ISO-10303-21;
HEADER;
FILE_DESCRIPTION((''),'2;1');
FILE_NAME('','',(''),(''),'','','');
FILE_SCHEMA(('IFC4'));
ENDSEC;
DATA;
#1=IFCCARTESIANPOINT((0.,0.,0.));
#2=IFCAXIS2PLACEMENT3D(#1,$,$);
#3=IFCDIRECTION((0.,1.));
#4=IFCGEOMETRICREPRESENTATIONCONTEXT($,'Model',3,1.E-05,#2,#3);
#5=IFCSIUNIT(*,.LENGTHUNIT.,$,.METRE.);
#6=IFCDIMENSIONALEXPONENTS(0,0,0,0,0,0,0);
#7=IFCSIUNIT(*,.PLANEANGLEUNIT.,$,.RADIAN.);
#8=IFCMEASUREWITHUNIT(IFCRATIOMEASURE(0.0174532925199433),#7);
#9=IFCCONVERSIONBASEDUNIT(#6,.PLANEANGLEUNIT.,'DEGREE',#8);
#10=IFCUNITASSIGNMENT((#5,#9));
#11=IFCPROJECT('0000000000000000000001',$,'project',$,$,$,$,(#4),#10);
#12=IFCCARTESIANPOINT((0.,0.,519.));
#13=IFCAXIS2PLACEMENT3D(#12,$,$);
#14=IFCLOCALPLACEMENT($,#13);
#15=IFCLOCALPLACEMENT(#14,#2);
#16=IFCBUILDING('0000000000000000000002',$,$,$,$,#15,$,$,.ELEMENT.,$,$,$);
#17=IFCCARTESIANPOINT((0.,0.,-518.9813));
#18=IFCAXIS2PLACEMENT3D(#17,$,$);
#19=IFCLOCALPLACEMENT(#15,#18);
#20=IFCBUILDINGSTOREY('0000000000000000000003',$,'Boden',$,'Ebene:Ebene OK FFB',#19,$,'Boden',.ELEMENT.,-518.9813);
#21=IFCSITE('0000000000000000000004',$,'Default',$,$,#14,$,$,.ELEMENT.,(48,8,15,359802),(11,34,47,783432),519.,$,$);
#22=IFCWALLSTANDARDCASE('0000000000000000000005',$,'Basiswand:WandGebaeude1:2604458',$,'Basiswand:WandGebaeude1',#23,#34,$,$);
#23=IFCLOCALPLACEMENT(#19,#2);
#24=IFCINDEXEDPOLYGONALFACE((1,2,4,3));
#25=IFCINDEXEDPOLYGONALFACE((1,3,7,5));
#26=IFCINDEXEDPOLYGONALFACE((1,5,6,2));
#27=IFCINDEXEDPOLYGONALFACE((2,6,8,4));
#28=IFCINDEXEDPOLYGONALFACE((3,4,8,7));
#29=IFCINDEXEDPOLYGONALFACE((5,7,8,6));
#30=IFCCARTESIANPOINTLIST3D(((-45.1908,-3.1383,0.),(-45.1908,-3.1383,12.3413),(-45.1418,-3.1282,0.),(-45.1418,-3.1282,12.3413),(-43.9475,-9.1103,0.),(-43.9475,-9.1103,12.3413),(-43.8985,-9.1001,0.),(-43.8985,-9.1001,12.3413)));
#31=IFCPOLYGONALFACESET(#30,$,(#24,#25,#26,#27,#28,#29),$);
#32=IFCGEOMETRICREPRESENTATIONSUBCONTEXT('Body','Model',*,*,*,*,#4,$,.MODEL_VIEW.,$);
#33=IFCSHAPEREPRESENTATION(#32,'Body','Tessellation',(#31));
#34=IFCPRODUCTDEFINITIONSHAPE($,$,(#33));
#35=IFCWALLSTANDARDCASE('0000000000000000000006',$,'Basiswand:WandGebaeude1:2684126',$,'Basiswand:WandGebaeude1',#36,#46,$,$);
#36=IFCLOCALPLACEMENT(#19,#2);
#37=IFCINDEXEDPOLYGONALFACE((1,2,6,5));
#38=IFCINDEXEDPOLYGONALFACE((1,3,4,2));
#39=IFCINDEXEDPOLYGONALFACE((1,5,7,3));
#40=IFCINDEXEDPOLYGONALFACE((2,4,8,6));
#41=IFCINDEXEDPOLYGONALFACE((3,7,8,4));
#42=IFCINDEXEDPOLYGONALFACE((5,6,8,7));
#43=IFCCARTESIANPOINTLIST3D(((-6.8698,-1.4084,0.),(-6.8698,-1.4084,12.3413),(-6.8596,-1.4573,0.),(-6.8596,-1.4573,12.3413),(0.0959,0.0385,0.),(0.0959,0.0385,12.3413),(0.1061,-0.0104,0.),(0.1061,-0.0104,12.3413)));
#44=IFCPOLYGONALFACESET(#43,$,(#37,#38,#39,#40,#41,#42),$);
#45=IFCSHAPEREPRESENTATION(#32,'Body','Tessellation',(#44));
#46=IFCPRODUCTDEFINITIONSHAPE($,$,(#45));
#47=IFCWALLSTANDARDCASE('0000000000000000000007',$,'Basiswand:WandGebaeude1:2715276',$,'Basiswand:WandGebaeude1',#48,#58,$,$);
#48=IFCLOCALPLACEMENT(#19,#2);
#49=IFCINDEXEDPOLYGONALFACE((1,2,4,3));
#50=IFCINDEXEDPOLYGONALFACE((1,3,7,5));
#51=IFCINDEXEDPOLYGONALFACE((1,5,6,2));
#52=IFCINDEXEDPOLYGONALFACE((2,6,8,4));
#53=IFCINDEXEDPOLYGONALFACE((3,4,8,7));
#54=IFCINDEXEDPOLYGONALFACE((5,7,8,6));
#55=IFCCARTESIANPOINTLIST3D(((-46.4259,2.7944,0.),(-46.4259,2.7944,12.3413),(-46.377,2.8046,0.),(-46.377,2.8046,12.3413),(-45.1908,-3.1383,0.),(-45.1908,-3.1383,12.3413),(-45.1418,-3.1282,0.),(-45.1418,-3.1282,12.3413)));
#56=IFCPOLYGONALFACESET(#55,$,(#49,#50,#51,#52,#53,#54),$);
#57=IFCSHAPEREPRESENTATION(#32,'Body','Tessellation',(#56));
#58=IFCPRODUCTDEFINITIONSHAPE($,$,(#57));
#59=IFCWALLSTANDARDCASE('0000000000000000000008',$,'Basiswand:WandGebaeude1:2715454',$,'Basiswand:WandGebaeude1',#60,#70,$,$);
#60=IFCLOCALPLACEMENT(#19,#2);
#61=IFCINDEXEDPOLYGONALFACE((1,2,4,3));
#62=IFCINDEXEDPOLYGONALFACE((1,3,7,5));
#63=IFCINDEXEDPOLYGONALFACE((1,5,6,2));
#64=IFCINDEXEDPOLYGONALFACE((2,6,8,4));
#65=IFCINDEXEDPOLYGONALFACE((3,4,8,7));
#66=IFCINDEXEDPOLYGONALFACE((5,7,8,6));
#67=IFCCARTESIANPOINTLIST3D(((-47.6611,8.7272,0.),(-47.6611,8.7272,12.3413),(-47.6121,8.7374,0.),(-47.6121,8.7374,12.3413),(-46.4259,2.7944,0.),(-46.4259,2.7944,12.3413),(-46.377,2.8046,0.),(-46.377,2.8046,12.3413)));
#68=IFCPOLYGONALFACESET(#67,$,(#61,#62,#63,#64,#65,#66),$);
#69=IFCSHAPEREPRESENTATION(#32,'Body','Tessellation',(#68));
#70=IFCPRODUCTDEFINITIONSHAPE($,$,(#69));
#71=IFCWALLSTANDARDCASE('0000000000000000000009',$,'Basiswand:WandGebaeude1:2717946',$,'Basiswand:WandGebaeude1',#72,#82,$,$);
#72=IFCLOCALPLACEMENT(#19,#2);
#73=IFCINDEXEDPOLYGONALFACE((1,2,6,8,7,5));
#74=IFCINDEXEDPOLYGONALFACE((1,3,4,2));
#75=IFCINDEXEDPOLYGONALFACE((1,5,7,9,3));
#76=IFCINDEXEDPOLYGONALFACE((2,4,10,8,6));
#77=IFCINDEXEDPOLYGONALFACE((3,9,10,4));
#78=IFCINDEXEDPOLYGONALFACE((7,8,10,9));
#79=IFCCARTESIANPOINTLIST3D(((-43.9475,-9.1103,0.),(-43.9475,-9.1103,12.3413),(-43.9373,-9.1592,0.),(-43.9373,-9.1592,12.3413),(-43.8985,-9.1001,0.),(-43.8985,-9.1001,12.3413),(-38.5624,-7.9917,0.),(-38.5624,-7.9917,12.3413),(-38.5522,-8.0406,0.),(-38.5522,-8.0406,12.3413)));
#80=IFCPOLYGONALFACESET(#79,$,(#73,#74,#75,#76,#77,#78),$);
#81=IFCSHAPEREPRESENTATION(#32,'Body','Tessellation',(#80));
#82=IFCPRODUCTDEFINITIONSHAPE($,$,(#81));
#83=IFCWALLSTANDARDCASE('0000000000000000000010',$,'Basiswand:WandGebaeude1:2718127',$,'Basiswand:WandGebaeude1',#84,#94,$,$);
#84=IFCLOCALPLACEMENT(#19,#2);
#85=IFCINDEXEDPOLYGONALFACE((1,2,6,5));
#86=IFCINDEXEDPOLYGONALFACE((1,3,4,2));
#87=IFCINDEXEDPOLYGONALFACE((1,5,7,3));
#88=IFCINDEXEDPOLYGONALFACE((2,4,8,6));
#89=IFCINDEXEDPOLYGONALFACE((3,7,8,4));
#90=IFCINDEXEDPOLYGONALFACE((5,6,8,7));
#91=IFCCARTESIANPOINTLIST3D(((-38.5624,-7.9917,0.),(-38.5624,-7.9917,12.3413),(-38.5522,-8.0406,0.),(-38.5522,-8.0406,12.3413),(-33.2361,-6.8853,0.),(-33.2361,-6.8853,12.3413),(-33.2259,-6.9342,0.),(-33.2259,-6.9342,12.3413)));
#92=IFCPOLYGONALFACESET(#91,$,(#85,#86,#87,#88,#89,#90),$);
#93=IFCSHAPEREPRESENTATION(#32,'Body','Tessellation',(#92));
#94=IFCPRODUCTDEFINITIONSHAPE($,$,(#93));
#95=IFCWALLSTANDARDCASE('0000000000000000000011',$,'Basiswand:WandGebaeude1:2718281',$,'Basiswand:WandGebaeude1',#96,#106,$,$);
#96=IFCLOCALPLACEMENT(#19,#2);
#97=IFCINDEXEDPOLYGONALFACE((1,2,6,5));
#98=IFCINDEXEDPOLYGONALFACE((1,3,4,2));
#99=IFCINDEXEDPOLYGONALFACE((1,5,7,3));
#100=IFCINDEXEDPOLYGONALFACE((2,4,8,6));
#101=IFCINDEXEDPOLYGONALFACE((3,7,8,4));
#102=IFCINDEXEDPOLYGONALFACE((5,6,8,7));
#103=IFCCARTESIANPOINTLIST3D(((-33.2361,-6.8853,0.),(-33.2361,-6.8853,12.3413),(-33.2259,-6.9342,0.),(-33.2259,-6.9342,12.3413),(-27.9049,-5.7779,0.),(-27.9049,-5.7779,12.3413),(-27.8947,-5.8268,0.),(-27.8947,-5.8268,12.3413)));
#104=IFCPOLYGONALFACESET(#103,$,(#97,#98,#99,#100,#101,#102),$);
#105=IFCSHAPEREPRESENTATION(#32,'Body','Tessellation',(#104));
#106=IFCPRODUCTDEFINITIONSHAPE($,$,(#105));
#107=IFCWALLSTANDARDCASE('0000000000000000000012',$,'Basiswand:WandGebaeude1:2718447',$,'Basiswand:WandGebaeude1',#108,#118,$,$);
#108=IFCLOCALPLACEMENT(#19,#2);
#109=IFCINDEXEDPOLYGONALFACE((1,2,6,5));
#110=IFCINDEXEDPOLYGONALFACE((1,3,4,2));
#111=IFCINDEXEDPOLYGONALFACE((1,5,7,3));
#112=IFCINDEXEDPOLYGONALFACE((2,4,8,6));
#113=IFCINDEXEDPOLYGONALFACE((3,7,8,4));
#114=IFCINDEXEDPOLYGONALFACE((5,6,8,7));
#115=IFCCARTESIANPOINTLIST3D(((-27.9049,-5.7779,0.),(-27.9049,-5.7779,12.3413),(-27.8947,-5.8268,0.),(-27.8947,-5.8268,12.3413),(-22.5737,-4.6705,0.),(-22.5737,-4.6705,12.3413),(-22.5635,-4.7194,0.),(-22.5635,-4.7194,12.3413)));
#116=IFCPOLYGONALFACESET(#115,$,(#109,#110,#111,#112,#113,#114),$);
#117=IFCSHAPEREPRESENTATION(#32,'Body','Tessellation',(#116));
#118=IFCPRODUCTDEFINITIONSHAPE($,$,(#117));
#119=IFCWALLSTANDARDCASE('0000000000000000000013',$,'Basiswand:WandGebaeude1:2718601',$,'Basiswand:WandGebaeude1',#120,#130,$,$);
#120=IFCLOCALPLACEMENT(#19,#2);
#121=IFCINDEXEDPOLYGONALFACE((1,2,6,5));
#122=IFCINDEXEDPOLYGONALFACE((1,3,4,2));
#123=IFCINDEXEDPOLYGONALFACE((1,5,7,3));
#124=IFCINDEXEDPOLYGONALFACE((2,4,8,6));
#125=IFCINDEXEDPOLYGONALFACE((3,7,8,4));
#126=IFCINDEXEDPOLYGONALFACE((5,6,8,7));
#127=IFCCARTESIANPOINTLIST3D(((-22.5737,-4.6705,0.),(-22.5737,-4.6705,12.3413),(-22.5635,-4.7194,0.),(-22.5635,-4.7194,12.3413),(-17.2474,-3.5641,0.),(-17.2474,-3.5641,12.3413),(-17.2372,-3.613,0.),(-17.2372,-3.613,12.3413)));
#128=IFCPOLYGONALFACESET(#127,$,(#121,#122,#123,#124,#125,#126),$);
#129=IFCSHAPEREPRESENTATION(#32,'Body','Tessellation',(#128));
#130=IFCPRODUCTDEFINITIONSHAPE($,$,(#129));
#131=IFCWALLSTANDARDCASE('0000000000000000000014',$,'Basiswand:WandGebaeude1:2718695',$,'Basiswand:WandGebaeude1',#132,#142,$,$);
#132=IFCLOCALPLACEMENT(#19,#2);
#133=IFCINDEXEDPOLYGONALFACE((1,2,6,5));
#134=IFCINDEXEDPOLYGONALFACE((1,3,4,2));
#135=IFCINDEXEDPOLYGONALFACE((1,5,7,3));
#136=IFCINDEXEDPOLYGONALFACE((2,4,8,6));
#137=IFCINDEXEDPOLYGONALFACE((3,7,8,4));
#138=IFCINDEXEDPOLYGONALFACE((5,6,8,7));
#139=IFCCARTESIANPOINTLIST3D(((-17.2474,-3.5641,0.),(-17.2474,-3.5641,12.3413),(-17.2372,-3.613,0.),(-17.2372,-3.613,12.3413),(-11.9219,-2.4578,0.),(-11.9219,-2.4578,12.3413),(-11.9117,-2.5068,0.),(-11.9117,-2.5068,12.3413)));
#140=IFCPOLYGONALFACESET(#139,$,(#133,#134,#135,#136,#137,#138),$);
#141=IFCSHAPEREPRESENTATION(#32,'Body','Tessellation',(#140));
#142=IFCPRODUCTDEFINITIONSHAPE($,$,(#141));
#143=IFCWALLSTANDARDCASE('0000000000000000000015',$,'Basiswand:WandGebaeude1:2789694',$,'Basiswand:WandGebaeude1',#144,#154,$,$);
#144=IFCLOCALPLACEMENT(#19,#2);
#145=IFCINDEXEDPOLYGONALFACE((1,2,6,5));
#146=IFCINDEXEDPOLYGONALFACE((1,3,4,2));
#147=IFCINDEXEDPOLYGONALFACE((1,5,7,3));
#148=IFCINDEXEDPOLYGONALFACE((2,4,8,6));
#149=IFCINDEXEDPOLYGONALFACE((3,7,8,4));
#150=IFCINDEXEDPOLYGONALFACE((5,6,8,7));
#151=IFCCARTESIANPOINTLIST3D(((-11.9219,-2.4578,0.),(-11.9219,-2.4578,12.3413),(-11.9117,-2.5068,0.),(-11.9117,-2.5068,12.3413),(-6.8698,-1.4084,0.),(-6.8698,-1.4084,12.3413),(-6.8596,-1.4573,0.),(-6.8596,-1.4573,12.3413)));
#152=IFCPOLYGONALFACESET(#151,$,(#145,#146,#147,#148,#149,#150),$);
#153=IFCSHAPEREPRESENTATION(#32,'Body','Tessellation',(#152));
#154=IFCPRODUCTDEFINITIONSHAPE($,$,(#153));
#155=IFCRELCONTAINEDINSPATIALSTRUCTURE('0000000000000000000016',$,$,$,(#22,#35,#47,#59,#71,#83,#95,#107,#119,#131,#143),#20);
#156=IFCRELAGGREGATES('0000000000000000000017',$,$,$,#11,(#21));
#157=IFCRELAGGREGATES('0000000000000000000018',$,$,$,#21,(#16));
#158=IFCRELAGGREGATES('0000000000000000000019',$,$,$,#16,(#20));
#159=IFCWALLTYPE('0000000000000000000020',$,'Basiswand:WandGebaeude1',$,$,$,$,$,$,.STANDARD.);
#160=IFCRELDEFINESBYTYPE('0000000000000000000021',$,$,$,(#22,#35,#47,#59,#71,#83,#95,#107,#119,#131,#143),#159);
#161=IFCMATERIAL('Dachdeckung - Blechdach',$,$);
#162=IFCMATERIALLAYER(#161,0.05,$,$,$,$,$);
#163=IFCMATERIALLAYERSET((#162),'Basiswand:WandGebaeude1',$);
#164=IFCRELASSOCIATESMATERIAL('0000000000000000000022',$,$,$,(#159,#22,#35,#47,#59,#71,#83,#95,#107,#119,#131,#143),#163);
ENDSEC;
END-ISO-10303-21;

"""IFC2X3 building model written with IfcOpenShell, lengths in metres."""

from ifc_helpers import new_model, entity, si_unit, converted_unit, direction, frame, frame_2d, origin, place, context, subcontext, project, spatial, polyline, rectangle, outline, extrude, material, layer, layer_set, layer_usage, type_object, element, save


model = new_model("IFC2X3")

# Units and contexts
model_context = context("Model", 3, precision=1e-05, world=origin(), true_north=direction((0.0, 1.0)))
body_context = subcontext(model_context, "Body", "Model", "MODEL_VIEW")
ifc_project = project(units=[si_unit("LENGTHUNIT", "METRE"), converted_unit("PLANEANGLEUNIT", "DEGREE", entity("IfcRatioMeasure", 0.0174532925199433), si_unit("PLANEANGLEUNIT", "RADIAN"), dimensions=[0, 0, 0, 0, 0, 0, 0])], contexts=[model_context])

# Site, building, storey
site_placement = place(None, frame((0.0, 0.0, 519.0)))
site = spatial("IfcSite", under=ifc_project, at=site_placement, Name="Default", CompositionType="ELEMENT", RefLatitude=(48, 8, 15, 359802), RefLongitude=(11, 34, 47, 783432), RefElevation=519.0)
building_placement = place(site_placement, origin())
building = spatial("IfcBuilding", under=site, at=building_placement, CompositionType="ELEMENT")
storey_placement = place(building_placement, frame((0.0, 0.0, -518.9813)))
storey = spatial("IfcBuildingStorey", under=building, at=storey_placement, Name="Boden", ObjectType="Ebene:Ebene OK FFB", LongName="Boden", CompositionType="ELEMENT", Elevation=-518.9813)

# Walls
ifc_material_1 = material(Name="Dachdeckung - Blechdach")
ifc_layer_1 = layer(ifc_material_1, 0.05)
ifc_layer_set_1 = layer_set([ifc_layer_1], Name="Basiswand:WandGebaeude1")
ifc_layer_usage_1 = layer_usage(ifc_layer_set_1, "AXIS2", "NEGATIVE", 0.025)
wall_type = type_object("IfcWallType", Name="Basiswand:WandGebaeude1", PredefinedType="STANDARD", material=ifc_layer_set_1)
wall_1_placement = place(storey_placement, frame((-43.923, -9.1052, 0.0), z_axis=(0.0, 0.0, 1.0), x_axis=(-0.20382, 0.979008, 0.0)))
element("IfcWallStandardCase", 1, at=wall_1_placement, inside=storey, type_object=wall_type, material=ifc_layer_usage_1, Name="Basiswand:WandGebaeude1:2604458", ObjectType="Basiswand:WandGebaeude1", context=body_context, shape_type="SweptSolid", body=[
    extrude(outline(polyline([(6.1, -0.025), (6.1, 0.025), (0.0, 0.025), (0.0, -0.025), (6.1, -0.025)])), origin(), (0.0, 0.0, 1.0), 12.3413),
])
ifc_layer_usage_2 = layer_usage(ifc_layer_set_1, "AXIS2", "NEGATIVE", 0.025)
wall_2_placement = place(storey_placement, frame((0.101, 0.0141, 0.0), z_axis=(0.0, 0.0, 1.0), x_axis=(-0.9791, -0.203381, 0.0)))
element("IfcWallStandardCase", 2, at=wall_2_placement, inside=storey, type_object=wall_type, material=ifc_layer_usage_2, Name="Basiswand:WandGebaeude1:2684126", ObjectType="Basiswand:WandGebaeude1", context=body_context, shape_type="SweptSolid", body=[
    extrude(outline(polyline([(7.1144, -0.025), (7.1144, 0.025), (0.0, 0.025), (0.0, -0.025), (7.1144, -0.025)])), origin(), (0.0, 0.0, 1.0), 12.3413),
])
ifc_layer_usage_3 = layer_usage(ifc_layer_set_1, "AXIS2", "NEGATIVE", 0.025)
wall_3_placement = place(storey_placement, frame((-45.1663, -3.1332, 0.0), z_axis=(0.0, 0.0, 1.0), x_axis=(-0.20382, 0.979008, 0.0)))
element("IfcWallStandardCase", 3, at=wall_3_placement, inside=storey, type_object=wall_type, material=ifc_layer_usage_3, Name="Basiswand:WandGebaeude1:2715276", ObjectType="Basiswand:WandGebaeude1", context=body_context, shape_type="SweptSolid", body=[
    extrude(rectangle(XDim=6.06, YDim=0.05, at=frame_2d((3.03, 0.0), x_axis=(-1.0, 0.0))), origin(), (0.0, 0.0, 1.0), 12.3413),
])
ifc_layer_usage_4 = layer_usage(ifc_layer_set_1, "AXIS2", "NEGATIVE", 0.025)
wall_4_placement = place(storey_placement, frame((-46.4014, 2.7995, 0.0), z_axis=(0.0, 0.0, 1.0), x_axis=(-0.20382, 0.979008, 0.0)))
element("IfcWallStandardCase", 4, at=wall_4_placement, inside=storey, type_object=wall_type, material=ifc_layer_usage_4, Name="Basiswand:WandGebaeude1:2715454", ObjectType="Basiswand:WandGebaeude1", context=body_context, shape_type="SweptSolid", body=[
    extrude(rectangle(XDim=6.06, YDim=0.05, at=frame_2d((3.03, 0.0), x_axis=(-1.0, 0.0))), origin(), (0.0, 0.0, 1.0), 12.3413),
])
ifc_layer_usage_5 = layer_usage(ifc_layer_set_1, "AXIS2", "NEGATIVE", 0.025)
wall_5_placement = place(storey_placement, frame((-38.5573, -8.0161, 0.0), z_axis=(0.0, 0.0, 1.0), x_axis=(-0.9791, -0.203381, 0.0)))
element("IfcWallStandardCase", 5, at=wall_5_placement, inside=storey, type_object=wall_type, material=ifc_layer_usage_5, Name="Basiswand:WandGebaeude1:2717946", ObjectType="Basiswand:WandGebaeude1", context=body_context, shape_type="SweptSolid", body=[
    extrude(outline(polyline([(5.5, -0.025), (5.5, 0.025), (0.0, 0.025), (0.0, -0.025), (5.45, -0.025), (5.5, -0.025)])), origin(), (0.0, 0.0, 1.0), 12.3413),
])
ifc_layer_usage_6 = layer_usage(ifc_layer_set_1, "AXIS2", "NEGATIVE", 0.025)
wall_6_placement = place(storey_placement, frame((-33.231, -6.9098, 0.0), z_axis=(0.0, 0.0, 1.0), x_axis=(-0.9791, -0.203381, 0.0)))
element("IfcWallStandardCase", 6, at=wall_6_placement, inside=storey, type_object=wall_type, material=ifc_layer_usage_6, Name="Basiswand:WandGebaeude1:2718127", ObjectType="Basiswand:WandGebaeude1", context=body_context, shape_type="SweptSolid", body=[
    extrude(rectangle(XDim=5.44, YDim=0.05, at=frame_2d((2.72, 0.0), x_axis=(-1.0, 0.0))), origin(), (0.0, 0.0, 1.0), 12.3413),
])
ifc_layer_usage_7 = layer_usage(ifc_layer_set_1, "AXIS2", "NEGATIVE", 0.025)
wall_7_placement = place(storey_placement, frame((-27.8998, -5.8023, 0.0), z_axis=(0.0, 0.0, 1.0), x_axis=(-0.9791, -0.203381, 0.0)))
element("IfcWallStandardCase", 7, at=wall_7_placement, inside=storey, type_object=wall_type, material=ifc_layer_usage_7, Name="Basiswand:WandGebaeude1:2718281", ObjectType="Basiswand:WandGebaeude1", context=body_context, shape_type="SweptSolid", body=[
    extrude(rectangle(XDim=5.445, YDim=0.05, at=frame_2d((2.7225, 0.0), x_axis=(-1.0, 0.0))), origin(), (0.0, 0.0, 1.0), 12.3413),
])
ifc_layer_usage_8 = layer_usage(ifc_layer_set_1, "AXIS2", "NEGATIVE", 0.025)
wall_8_placement = place(storey_placement, frame((-22.5686, -4.6949, 0.0), z_axis=(0.0, 0.0, 1.0), x_axis=(-0.9791, -0.203381, 0.0)))
element("IfcWallStandardCase", 8, at=wall_8_placement, inside=storey, type_object=wall_type, material=ifc_layer_usage_8, Name="Basiswand:WandGebaeude1:2718447", ObjectType="Basiswand:WandGebaeude1", context=body_context, shape_type="SweptSolid", body=[
    extrude(rectangle(XDim=5.445, YDim=0.05, at=frame_2d((2.7225, 0.0), x_axis=(-1.0, 0.0))), origin(), (0.0, 0.0, 1.0), 12.3413),
])
ifc_layer_usage_9 = layer_usage(ifc_layer_set_1, "AXIS2", "NEGATIVE", 0.025)
wall_9_placement = place(storey_placement, frame((-17.2423, -3.5885, 0.0), z_axis=(0.0, 0.0, 1.0), x_axis=(-0.9791, -0.203381, 0.0)))
element("IfcWallStandardCase", 9, at=wall_9_placement, inside=storey, type_object=wall_type, material=ifc_layer_usage_9, Name="Basiswand:WandGebaeude1:2718601", ObjectType="Basiswand:WandGebaeude1", context=body_context, shape_type="SweptSolid", body=[
    extrude(rectangle(XDim=5.44, YDim=0.05, at=frame_2d((2.72, 0.0), x_axis=(-1.0, 0.0))), origin(), (0.0, 0.0, 1.0), 12.3413),
])
ifc_layer_usage_10 = layer_usage(ifc_layer_set_1, "AXIS2", "NEGATIVE", 0.025)
wall_10_placement = place(storey_placement, frame((-11.9168, -2.4823, 0.0), z_axis=(0.0, 0.0, 1.0), x_axis=(-0.9791, -0.203381, 0.0)))
element("IfcWallStandardCase", 10, at=wall_10_placement, inside=storey, type_object=wall_type, material=ifc_layer_usage_10, Name="Basiswand:WandGebaeude1:2718695", ObjectType="Basiswand:WandGebaeude1", context=body_context, shape_type="SweptSolid", body=[
    extrude(rectangle(XDim=5.4392, YDim=0.05, at=frame_2d((2.7196, 0.0), x_axis=(-1.0, 0.0))), origin(), (0.0, 0.0, 1.0), 12.3413),
])
ifc_layer_usage_11 = layer_usage(ifc_layer_set_1, "AXIS2", "NEGATIVE", 0.025)
wall_11_placement = place(storey_placement, frame((-6.8647, -1.4329, 0.0), z_axis=(0.0, 0.0, 1.0), x_axis=(-0.9791, -0.203381, 0.0)))
element("IfcWallStandardCase", 11, at=wall_11_placement, inside=storey, type_object=wall_type, material=ifc_layer_usage_11, Name="Basiswand:WandGebaeude1:2789694", ObjectType="Basiswand:WandGebaeude1", context=body_context, shape_type="SweptSolid", body=[
    extrude(rectangle(XDim=5.16, YDim=0.05, at=frame_2d((2.58, 0.0), x_axis=(-1.0, 0.0))), origin(), (0.0, 0.0, 1.0), 12.3413),
])

save(model, "model.ifc")
